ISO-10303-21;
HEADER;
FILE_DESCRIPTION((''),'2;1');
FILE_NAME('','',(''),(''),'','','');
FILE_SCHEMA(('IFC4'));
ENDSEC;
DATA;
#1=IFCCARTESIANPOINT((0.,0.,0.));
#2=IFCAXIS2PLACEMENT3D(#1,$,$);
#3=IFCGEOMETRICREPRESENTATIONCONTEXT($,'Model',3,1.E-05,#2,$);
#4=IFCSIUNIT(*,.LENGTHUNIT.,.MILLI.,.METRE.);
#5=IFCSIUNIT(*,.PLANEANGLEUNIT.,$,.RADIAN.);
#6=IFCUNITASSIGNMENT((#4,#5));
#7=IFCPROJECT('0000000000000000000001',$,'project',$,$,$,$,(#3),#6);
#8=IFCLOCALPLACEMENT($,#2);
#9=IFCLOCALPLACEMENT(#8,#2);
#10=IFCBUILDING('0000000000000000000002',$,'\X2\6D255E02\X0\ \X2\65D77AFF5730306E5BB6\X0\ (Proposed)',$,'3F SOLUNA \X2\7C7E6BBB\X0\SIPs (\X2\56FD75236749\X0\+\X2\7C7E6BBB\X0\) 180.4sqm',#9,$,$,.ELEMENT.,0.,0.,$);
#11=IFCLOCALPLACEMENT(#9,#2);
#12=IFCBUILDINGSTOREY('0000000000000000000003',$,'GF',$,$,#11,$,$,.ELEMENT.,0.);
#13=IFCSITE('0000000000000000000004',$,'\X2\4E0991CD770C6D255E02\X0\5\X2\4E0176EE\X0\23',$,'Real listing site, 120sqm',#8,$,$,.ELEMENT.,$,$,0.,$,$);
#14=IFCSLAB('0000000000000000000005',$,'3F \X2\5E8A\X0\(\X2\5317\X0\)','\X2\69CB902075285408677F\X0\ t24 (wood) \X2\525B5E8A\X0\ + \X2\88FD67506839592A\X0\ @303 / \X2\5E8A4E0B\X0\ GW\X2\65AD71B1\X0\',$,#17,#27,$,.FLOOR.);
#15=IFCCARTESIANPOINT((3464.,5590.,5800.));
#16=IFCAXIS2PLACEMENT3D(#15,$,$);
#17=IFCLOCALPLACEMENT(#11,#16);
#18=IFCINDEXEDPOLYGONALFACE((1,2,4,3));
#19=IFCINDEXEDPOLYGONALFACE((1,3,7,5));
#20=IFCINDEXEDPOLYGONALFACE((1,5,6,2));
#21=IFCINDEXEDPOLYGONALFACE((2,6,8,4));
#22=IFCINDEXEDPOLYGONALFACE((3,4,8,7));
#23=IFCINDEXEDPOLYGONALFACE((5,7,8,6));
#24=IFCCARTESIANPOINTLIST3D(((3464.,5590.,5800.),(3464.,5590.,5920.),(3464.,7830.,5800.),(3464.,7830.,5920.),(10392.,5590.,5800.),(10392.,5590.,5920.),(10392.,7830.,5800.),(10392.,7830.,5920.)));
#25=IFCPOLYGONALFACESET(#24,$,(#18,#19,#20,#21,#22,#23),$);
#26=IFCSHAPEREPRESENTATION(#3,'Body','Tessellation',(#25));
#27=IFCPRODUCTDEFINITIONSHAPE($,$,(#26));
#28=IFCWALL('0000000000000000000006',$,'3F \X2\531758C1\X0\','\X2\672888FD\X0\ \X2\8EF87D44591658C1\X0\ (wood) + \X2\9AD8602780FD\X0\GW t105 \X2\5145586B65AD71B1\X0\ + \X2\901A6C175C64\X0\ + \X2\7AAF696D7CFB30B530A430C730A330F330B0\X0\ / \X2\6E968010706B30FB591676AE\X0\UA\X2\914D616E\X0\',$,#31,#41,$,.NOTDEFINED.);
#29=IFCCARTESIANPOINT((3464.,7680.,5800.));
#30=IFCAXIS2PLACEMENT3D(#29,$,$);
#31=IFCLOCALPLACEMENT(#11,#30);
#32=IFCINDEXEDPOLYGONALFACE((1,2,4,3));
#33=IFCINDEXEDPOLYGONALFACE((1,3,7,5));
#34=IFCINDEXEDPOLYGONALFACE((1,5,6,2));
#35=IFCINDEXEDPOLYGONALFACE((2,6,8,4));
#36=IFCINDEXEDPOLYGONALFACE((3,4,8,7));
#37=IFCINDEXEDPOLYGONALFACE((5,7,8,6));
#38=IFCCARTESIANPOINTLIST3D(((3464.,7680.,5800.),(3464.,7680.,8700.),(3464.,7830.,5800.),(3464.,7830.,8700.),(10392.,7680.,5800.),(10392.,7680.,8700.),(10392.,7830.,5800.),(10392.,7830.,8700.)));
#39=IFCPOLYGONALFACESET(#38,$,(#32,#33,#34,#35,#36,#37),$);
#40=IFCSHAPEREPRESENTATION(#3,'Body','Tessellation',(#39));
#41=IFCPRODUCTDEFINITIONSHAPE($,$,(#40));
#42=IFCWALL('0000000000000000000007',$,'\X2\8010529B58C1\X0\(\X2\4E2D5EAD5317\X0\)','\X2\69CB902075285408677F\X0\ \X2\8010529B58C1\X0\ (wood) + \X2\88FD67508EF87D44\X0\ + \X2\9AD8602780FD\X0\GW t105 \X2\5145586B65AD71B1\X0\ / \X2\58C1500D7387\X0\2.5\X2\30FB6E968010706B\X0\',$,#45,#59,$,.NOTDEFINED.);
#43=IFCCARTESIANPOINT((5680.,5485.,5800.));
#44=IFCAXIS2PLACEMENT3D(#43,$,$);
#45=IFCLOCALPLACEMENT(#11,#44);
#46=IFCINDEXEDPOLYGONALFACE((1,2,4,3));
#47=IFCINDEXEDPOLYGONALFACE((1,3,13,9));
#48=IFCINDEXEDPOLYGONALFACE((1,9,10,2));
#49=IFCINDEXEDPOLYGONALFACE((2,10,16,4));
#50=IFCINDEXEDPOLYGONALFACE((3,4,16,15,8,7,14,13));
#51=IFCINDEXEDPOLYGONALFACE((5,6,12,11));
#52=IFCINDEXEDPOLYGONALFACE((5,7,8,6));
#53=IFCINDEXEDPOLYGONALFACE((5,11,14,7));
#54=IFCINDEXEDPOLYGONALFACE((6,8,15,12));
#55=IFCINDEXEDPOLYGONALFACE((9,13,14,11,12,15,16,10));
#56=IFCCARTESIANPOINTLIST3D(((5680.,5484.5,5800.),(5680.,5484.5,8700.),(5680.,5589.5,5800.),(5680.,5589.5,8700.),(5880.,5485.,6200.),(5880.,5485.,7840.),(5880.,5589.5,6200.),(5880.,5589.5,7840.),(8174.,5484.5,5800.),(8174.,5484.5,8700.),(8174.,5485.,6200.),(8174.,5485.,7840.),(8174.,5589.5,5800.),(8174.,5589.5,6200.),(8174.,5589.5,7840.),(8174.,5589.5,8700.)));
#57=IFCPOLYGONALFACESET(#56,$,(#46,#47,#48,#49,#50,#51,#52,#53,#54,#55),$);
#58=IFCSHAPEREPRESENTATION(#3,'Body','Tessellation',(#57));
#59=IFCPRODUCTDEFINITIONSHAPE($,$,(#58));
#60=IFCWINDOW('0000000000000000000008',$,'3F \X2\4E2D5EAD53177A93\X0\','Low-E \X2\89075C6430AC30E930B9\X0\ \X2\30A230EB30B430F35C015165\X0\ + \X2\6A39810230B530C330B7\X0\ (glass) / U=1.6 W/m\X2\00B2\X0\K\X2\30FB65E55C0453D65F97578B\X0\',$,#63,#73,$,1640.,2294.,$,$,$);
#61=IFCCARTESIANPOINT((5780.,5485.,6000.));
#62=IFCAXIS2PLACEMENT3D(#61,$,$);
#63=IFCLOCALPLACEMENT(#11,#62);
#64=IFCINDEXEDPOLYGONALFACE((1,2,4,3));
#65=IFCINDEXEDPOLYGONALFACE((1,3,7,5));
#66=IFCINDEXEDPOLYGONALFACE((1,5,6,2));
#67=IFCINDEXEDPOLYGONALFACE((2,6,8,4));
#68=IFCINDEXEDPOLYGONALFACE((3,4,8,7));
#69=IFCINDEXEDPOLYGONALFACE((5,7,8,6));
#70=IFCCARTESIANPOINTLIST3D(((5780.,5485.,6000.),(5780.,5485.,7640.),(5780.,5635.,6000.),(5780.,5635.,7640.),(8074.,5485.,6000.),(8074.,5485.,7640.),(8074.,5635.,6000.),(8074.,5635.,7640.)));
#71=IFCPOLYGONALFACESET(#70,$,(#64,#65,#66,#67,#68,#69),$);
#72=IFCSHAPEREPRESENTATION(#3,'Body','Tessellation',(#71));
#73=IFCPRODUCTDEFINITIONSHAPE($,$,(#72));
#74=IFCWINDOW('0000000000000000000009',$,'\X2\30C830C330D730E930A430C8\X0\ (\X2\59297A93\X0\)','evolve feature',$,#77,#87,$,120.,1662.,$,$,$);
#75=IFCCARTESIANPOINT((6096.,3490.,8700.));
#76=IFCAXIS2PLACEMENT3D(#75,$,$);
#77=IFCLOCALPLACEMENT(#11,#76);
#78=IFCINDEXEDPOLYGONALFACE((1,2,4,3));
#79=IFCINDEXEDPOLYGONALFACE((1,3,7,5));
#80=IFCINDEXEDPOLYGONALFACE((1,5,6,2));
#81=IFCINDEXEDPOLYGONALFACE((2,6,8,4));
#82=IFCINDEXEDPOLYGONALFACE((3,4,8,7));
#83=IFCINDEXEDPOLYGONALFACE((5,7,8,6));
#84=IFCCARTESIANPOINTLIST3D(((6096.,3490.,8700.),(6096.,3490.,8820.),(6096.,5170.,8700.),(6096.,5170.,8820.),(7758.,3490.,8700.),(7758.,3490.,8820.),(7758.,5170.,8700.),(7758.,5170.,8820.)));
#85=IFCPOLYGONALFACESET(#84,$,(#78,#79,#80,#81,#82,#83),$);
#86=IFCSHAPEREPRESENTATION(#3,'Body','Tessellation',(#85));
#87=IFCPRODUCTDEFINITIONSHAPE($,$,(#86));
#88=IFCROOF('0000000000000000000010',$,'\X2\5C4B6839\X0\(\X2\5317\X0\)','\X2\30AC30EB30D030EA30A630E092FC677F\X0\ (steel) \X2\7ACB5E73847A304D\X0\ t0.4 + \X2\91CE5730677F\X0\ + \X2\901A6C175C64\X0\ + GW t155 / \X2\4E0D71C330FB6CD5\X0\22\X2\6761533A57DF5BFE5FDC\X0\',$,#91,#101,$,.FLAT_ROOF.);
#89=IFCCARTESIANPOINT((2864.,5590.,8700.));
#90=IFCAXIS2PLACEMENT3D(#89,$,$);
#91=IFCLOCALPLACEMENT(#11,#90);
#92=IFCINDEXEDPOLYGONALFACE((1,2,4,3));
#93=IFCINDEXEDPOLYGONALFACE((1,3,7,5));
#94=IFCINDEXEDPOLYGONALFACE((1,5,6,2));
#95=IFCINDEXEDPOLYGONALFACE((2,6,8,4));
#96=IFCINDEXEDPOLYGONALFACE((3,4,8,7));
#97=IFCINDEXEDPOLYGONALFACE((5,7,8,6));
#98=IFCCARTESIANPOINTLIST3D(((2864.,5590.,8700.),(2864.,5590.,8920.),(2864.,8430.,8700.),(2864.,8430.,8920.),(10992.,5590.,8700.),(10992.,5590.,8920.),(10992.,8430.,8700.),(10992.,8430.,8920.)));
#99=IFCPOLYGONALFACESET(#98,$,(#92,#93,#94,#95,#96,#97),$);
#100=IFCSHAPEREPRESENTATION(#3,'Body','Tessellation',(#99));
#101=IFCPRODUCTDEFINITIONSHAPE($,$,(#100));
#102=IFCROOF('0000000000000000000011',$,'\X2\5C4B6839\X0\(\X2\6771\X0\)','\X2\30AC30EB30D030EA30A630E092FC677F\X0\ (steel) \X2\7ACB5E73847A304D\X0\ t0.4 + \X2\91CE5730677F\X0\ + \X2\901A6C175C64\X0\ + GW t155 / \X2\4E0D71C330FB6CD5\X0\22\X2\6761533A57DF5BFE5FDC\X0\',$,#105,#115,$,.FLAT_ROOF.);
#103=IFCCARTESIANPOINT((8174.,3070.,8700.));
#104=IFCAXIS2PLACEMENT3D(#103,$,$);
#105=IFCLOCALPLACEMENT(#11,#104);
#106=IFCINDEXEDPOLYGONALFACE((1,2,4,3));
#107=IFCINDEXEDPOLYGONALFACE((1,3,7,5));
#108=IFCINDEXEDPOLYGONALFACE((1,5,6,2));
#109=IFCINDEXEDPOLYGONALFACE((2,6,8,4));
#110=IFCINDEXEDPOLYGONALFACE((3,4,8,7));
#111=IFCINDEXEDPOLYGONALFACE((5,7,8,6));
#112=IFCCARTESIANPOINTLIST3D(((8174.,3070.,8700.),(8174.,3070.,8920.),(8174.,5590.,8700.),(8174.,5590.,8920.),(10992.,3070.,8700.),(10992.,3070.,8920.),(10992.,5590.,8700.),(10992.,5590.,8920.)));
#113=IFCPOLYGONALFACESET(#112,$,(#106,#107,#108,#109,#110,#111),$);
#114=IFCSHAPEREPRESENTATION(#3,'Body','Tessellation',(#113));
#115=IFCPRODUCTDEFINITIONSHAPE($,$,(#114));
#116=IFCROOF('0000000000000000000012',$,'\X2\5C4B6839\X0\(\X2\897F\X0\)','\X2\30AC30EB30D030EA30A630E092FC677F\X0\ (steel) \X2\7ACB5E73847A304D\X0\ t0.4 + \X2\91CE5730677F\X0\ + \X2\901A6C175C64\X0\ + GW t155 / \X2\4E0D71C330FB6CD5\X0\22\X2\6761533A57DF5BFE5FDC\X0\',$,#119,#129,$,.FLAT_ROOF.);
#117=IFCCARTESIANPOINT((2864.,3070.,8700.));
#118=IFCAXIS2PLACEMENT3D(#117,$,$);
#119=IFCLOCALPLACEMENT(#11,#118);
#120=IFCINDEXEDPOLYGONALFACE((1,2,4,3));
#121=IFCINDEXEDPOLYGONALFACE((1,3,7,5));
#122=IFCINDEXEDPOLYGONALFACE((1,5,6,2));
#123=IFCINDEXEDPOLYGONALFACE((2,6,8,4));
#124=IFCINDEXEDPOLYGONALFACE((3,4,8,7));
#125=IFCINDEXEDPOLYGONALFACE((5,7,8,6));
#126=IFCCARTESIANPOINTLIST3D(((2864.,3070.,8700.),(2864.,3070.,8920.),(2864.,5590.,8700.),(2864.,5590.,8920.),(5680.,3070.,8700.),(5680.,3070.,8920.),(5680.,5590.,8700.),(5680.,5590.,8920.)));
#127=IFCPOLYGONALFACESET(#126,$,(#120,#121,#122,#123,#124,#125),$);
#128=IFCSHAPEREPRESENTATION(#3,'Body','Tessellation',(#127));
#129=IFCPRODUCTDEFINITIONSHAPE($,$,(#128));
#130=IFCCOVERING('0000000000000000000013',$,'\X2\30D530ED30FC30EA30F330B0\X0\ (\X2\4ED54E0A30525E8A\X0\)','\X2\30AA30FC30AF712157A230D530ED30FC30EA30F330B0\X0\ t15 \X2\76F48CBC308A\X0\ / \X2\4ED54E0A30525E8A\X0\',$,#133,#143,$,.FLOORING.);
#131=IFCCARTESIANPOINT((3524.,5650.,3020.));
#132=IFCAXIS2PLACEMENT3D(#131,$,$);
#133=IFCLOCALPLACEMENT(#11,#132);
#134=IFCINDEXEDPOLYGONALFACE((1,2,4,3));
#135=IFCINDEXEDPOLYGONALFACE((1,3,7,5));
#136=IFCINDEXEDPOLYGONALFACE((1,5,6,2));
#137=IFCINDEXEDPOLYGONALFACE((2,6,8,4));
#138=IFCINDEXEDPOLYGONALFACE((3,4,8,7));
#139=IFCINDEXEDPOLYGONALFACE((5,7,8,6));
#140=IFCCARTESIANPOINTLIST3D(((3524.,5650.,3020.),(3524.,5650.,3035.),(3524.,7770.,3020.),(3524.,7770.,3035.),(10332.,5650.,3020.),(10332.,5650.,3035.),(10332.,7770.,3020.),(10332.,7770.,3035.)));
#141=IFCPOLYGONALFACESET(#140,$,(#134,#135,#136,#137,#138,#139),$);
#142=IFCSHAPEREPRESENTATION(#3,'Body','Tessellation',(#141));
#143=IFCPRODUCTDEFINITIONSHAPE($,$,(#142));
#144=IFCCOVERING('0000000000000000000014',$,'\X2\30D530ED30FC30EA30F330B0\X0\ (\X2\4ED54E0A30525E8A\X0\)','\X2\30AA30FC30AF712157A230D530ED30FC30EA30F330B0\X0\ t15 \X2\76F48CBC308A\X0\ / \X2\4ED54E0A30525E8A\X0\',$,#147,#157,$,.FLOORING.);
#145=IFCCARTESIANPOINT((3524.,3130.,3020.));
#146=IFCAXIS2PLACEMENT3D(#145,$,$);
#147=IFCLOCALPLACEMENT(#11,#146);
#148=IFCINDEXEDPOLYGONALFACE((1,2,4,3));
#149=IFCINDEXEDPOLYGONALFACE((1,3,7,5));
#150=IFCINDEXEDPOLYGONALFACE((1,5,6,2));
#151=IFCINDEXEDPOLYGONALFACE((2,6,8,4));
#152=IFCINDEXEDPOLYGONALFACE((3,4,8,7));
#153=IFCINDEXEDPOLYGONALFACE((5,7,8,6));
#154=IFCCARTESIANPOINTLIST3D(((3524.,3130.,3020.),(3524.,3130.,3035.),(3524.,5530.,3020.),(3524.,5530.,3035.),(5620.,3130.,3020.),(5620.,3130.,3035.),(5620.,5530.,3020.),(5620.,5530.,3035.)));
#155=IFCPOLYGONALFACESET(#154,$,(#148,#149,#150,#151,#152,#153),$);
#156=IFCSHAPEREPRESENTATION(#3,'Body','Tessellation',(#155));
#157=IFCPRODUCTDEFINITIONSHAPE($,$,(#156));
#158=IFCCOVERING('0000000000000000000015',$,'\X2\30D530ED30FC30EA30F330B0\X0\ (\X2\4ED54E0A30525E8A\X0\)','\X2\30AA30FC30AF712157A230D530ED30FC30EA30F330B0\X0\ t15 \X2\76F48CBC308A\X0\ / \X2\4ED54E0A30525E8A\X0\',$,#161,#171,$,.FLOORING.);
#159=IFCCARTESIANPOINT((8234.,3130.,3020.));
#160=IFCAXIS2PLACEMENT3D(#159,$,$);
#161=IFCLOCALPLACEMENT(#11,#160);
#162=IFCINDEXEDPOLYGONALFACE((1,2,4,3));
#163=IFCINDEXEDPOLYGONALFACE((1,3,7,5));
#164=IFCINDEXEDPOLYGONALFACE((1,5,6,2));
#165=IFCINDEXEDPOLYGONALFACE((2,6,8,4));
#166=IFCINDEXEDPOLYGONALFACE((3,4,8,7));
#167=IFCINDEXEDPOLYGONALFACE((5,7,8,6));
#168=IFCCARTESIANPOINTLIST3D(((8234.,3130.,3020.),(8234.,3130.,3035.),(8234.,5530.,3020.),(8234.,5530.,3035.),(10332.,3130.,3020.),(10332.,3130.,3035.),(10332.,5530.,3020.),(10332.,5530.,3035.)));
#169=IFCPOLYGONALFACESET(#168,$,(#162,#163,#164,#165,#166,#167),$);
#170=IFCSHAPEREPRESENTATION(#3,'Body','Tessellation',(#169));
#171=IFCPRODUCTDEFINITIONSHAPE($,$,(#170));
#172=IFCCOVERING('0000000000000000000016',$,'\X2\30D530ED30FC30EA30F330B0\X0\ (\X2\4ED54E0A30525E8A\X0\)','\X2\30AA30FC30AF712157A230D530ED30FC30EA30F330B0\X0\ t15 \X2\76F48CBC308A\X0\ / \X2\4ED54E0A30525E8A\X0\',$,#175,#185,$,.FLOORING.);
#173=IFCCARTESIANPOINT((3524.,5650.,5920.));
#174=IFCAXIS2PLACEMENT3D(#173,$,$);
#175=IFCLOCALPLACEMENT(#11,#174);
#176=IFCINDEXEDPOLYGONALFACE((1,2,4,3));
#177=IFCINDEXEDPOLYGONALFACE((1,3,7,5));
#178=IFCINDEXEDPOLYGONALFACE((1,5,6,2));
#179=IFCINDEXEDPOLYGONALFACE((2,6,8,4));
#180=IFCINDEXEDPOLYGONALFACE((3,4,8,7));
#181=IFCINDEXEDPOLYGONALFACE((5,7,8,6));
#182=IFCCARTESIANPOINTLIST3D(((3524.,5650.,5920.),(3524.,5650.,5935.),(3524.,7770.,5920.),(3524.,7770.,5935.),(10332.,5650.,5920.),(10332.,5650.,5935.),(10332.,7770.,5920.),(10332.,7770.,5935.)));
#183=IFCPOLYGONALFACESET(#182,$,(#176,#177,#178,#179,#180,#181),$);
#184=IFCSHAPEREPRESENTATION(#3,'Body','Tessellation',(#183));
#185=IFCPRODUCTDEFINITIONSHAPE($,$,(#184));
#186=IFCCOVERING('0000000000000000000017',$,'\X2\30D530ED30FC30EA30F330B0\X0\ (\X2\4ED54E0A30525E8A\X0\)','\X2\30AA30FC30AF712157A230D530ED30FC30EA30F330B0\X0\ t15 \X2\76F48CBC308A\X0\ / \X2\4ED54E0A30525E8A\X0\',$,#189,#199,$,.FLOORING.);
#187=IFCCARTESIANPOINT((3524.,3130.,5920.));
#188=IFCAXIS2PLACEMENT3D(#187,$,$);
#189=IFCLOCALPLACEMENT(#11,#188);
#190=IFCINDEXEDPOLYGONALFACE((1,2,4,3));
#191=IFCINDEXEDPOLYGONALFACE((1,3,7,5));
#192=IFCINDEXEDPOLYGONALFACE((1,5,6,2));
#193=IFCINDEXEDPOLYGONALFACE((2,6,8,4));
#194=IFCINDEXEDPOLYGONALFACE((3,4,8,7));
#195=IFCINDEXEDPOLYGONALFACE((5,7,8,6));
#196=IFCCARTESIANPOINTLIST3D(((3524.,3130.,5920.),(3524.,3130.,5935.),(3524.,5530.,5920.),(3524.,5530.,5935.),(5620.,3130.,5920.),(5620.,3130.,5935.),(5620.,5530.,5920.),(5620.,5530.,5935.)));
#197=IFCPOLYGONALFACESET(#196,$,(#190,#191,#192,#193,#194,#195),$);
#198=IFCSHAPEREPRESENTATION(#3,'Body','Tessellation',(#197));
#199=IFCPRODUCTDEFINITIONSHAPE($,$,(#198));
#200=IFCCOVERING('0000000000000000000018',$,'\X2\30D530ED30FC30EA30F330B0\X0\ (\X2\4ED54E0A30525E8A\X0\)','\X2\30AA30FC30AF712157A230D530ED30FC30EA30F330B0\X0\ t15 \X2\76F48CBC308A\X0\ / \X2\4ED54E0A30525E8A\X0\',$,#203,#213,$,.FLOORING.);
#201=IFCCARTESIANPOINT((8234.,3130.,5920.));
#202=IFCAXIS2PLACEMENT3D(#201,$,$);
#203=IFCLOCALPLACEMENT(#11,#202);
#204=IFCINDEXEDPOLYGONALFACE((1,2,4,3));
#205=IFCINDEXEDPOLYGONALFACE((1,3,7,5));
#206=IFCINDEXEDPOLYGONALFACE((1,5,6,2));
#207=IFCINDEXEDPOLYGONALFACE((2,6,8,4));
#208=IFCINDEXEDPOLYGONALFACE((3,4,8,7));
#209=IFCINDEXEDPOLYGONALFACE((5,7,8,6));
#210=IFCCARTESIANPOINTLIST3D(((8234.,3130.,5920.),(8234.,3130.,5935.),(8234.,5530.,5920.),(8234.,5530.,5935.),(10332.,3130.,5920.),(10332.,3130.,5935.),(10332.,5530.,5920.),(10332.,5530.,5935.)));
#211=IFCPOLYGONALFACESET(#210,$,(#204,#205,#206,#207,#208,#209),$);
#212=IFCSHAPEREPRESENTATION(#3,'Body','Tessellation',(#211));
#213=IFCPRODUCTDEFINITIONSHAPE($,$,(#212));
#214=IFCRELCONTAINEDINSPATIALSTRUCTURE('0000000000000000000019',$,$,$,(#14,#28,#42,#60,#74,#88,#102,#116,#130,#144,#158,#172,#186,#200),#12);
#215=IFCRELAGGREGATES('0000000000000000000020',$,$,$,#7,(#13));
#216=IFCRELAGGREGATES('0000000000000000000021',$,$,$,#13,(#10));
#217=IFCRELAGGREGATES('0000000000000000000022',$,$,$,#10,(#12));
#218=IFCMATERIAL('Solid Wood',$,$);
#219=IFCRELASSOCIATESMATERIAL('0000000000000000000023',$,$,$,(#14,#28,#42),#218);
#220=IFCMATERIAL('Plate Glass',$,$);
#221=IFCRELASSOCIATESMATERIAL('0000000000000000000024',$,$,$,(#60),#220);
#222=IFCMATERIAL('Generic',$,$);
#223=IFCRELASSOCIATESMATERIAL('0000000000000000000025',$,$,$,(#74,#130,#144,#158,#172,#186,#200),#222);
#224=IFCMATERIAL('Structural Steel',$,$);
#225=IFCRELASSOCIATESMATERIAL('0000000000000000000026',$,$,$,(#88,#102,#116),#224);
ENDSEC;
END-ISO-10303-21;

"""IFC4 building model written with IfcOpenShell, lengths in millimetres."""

from ifc_helpers import new_model, si_unit, frame, frame_2d, origin, place, context, project, spatial, rectangle, extrude, material, element, fill, save


model = new_model("IFC4")

# Units and contexts
model_context = context("Model", 3, precision=1e-05, world=origin())
ifc_project = project(units=[si_unit("LENGTHUNIT", "METRE", prefix="MILLI"), si_unit("PLANEANGLEUNIT", "RADIAN")], contexts=[model_context])

# Site, building, storey
site_placement = place(None, origin())
site = spatial("IfcSite", under=ifc_project, at=site_placement, Name="三重県津市5丁目23", ObjectType="Real listing site, 120sqm", CompositionType="ELEMENT", RefElevation=0.0)
building_placement = place(site_placement, origin())
building = spatial("IfcBuilding", under=site, at=building_placement, Name="津市 旗竿地の家 (Proposed)", ObjectType="3F SOLUNA 籾殻SIPs (国産杉+籾殻) 180.4sqm", CompositionType="ELEMENT", ElevationOfRefHeight=0.0, ElevationOfTerrain=0.0)
storey_placement = place(building_placement, origin())
storey = spatial("IfcBuildingStorey", under=building, at=storey_placement, Name="GF", CompositionType="ELEMENT", Elevation=0.0)

# Slab
ifc_material_1 = material(Name="Solid Wood")
slab_placement = place(storey_placement, frame((3464.0, 5590.0, 5800.0)))
element("IfcSlab", 1, at=slab_placement, inside=storey, material=ifc_material_1, Name="3F 床(北)", Description="構造用合板 t24 (wood) 剛床 + 製材根太 @303 / 床下 GW断熱", PredefinedType="FLOOR", context=model_context, shape_type="SweptSolid", body=[
    extrude(rectangle(XDim=6928.0, YDim=2240.0, at=frame_2d((3464.0, 1120.0))), frame((3464.0, 5590.0, 5800.0)), (0.0, 0.0, 1.0), 120.0),
])

# Wall
wall_1_placement = place(storey_placement, frame((3464.0, 7680.0, 5800.0)))
element("IfcWall", 2, at=wall_1_placement, inside=storey, material=ifc_material_1, Name="3F 北壁", Description="木製 軸組外壁 (wood) + 高性能GW t105 充填断熱 + 通気層 + 窯業系サイディング / 準耐火・外皮UA配慮", PredefinedType="NOTDEFINED", context=model_context, shape_type="SweptSolid", body=[
    extrude(rectangle(XDim=6928.0, YDim=150.0, at=frame_2d((3464.0, 75.0))), frame((3464.0, 7680.0, 5800.0)), (0.0, 0.0, 1.0), 2900.0),
])

# Wall, opening, window
wall_2_placement = place(storey_placement, frame((5680.0, 5485.0, 5800.0)))
wall_2 = element("IfcWall", 3, at=wall_2_placement, inside=storey, material=ifc_material_1, Name="耐力壁(中庭北)", Description="構造用合板 耐力壁 (wood) + 製材軸組 + 高性能GW t105 充填断熱 / 壁倍率2.5・準耐火", PredefinedType="NOTDEFINED", context=model_context, shape_type="SweptSolid", body=[
    extrude(rectangle(XDim=2494.0, YDim=105.0, at=frame_2d((1247.0, 52.0))), frame((5680.0, 5485.0, 5800.0)), (0.0, 0.0, 1.0), 2900.0),
])
opening_placement = place(storey_placement, frame((5780.0, 5485.0, 6000.0)))
opening = element("IfcOpeningElement", 4, at=opening_placement, cuts=wall_2, PredefinedType="NOTDEFINED", context=model_context, shape_type="SweptSolid", body=[
    extrude(rectangle(XDim=2294.0, YDim=150.0, at=frame_2d((1147.0, 75.0))), frame((5780.0, 5485.0, 6000.0)), (0.0, 0.0, 1.0), 1640.0),
])
ifc_material_2 = material(Name="Plate Glass")
window_1_placement = place(storey_placement, frame((5780.0, 5485.0, 6000.0)))
window_1 = element("IfcWindow", 5, at=window_1_placement, inside=storey, material=ifc_material_2, Name="3F 中庭北窓", Description="Low-E 複層ガラス アルゴン封入 + 樹脂サッシ (glass) / U=1.6 W/m²K・日射取得型", OverallHeight=1640.0, OverallWidth=2294.0, context=model_context, shape_type="SweptSolid", body=[
    extrude(rectangle(XDim=2294.0, YDim=150.0, at=frame_2d((1147.0, 75.0))), frame((5780.0, 5485.0, 6000.0)), (0.0, 0.0, 1.0), 1640.0),
])
fill(opening, window_1)

# Window
ifc_material_3 = material(Name="Generic")
window_2_placement = place(storey_placement, frame((6096.0, 3490.0, 8700.0)))
element("IfcWindow", 6, at=window_2_placement, inside=storey, material=ifc_material_3, Name="トップライト (天窓)", Description="evolve feature", OverallHeight=120.0, OverallWidth=1662.0, context=model_context, shape_type="SweptSolid", body=[
    extrude(rectangle(XDim=1662.0, YDim=1680.0, at=frame_2d((831.0, 840.0))), frame((6096.0, 3490.0, 8700.0)), (0.0, 0.0, 1.0), 120.0),
])

# Roofs
ifc_material_4 = material(Name="Structural Steel")
roof_1_placement = place(storey_placement, frame((2864.0, 5590.0, 8700.0)))
element("IfcRoof", 7, at=roof_1_placement, inside=storey, material=ifc_material_4, Name="屋根(北)", Description="ガルバリウム鋼板 (steel) 立平葺き t0.4 + 野地板 + 通気層 + GW t155 / 不燃・法22条区域対応", PredefinedType="FLAT_ROOF", context=model_context, shape_type="SweptSolid", body=[
    extrude(rectangle(XDim=8128.0, YDim=2840.0, at=frame_2d((4064.0, 1420.0))), frame((2864.0, 5590.0, 8700.0)), (0.0, 0.0, 1.0), 220.0),
])
roof_2_placement = place(storey_placement, frame((8174.0, 3070.0, 8700.0)))
element("IfcRoof", 8, at=roof_2_placement, inside=storey, material=ifc_material_4, Name="屋根(東)", Description="ガルバリウム鋼板 (steel) 立平葺き t0.4 + 野地板 + 通気層 + GW t155 / 不燃・法22条区域対応", PredefinedType="FLAT_ROOF", context=model_context, shape_type="SweptSolid", body=[
    extrude(rectangle(XDim=2818.0, YDim=2520.0, at=frame_2d((1409.0, 1260.0))), frame((8174.0, 3070.0, 8700.0)), (0.0, 0.0, 1.0), 220.0),
])
roof_3_placement = place(storey_placement, frame((2864.0, 3070.0, 8700.0)))
element("IfcRoof", 9, at=roof_3_placement, inside=storey, material=ifc_material_4, Name="屋根(西)", Description="ガルバリウム鋼板 (steel) 立平葺き t0.4 + 野地板 + 通気層 + GW t155 / 不燃・法22条区域対応", PredefinedType="FLAT_ROOF", context=model_context, shape_type="SweptSolid", body=[
    extrude(rectangle(XDim=2816.0, YDim=2520.0, at=frame_2d((1408.0, 1260.0))), frame((2864.0, 3070.0, 8700.0)), (0.0, 0.0, 1.0), 220.0),
])

# Coverings
covering_1_placement = place(storey_placement, frame((3524.0, 5650.0, 3020.0)))
element("IfcCovering", 10, at=covering_1_placement, inside=storey, material=ifc_material_3, Name="フローリング (仕上げ床)", Description="オーク無垢フローリング t15 直貼り / 仕上げ床", PredefinedType="FLOORING", context=model_context, shape_type="SweptSolid", body=[
    extrude(rectangle(XDim=6808.0, YDim=2120.0, at=frame_2d((3404.0, 1060.0))), frame((3524.0, 5650.0, 3020.0)), (0.0, 0.0, 1.0), 15.0),
])
covering_2_placement = place(storey_placement, frame((3524.0, 3130.0, 3020.0)))
element("IfcCovering", 11, at=covering_2_placement, inside=storey, material=ifc_material_3, Name="フローリング (仕上げ床)", Description="オーク無垢フローリング t15 直貼り / 仕上げ床", PredefinedType="FLOORING", context=model_context, shape_type="SweptSolid", body=[
    extrude(rectangle(XDim=2096.0, YDim=2400.0, at=frame_2d((1048.0, 1200.0))), frame((3524.0, 3130.0, 3020.0)), (0.0, 0.0, 1.0), 15.0),
])
covering_3_placement = place(storey_placement, frame((8234.0, 3130.0, 3020.0)))
element("IfcCovering", 12, at=covering_3_placement, inside=storey, material=ifc_material_3, Name="フローリング (仕上げ床)", Description="オーク無垢フローリング t15 直貼り / 仕上げ床", PredefinedType="FLOORING", context=model_context, shape_type="SweptSolid", body=[
    extrude(rectangle(XDim=2098.0, YDim=2400.0, at=frame_2d((1049.0, 1200.0))), frame((8234.0, 3130.0, 3020.0)), (0.0, 0.0, 1.0), 15.0),
])
covering_4_placement = place(storey_placement, frame((3524.0, 5650.0, 5920.0)))
element("IfcCovering", 13, at=covering_4_placement, inside=storey, material=ifc_material_3, Name="フローリング (仕上げ床)", Description="オーク無垢フローリング t15 直貼り / 仕上げ床", PredefinedType="FLOORING", context=model_context, shape_type="SweptSolid", body=[
    extrude(rectangle(XDim=6808.0, YDim=2120.0, at=frame_2d((3404.0, 1060.0))), frame((3524.0, 5650.0, 5920.0)), (0.0, 0.0, 1.0), 15.0),
])
covering_5_placement = place(storey_placement, frame((3524.0, 3130.0, 5920.0)))
element("IfcCovering", 14, at=covering_5_placement, inside=storey, material=ifc_material_3, Name="フローリング (仕上げ床)", Description="オーク無垢フローリング t15 直貼り / 仕上げ床", PredefinedType="FLOORING", context=model_context, shape_type="SweptSolid", body=[
    extrude(rectangle(XDim=2096.0, YDim=2400.0, at=frame_2d((1048.0, 1200.0))), frame((3524.0, 3130.0, 5920.0)), (0.0, 0.0, 1.0), 15.0),
])
covering_6_placement = place(storey_placement, frame((8234.0, 3130.0, 5920.0)))
element("IfcCovering", 15, at=covering_6_placement, inside=storey, material=ifc_material_3, Name="フローリング (仕上げ床)", Description="オーク無垢フローリング t15 直貼り / 仕上げ床", PredefinedType="FLOORING", context=model_context, shape_type="SweptSolid", body=[
    extrude(rectangle(XDim=2098.0, YDim=2400.0, at=frame_2d((1049.0, 1200.0))), frame((8234.0, 3130.0, 5920.0)), (0.0, 0.0, 1.0), 15.0),
])

save(model, "model.ifc")
